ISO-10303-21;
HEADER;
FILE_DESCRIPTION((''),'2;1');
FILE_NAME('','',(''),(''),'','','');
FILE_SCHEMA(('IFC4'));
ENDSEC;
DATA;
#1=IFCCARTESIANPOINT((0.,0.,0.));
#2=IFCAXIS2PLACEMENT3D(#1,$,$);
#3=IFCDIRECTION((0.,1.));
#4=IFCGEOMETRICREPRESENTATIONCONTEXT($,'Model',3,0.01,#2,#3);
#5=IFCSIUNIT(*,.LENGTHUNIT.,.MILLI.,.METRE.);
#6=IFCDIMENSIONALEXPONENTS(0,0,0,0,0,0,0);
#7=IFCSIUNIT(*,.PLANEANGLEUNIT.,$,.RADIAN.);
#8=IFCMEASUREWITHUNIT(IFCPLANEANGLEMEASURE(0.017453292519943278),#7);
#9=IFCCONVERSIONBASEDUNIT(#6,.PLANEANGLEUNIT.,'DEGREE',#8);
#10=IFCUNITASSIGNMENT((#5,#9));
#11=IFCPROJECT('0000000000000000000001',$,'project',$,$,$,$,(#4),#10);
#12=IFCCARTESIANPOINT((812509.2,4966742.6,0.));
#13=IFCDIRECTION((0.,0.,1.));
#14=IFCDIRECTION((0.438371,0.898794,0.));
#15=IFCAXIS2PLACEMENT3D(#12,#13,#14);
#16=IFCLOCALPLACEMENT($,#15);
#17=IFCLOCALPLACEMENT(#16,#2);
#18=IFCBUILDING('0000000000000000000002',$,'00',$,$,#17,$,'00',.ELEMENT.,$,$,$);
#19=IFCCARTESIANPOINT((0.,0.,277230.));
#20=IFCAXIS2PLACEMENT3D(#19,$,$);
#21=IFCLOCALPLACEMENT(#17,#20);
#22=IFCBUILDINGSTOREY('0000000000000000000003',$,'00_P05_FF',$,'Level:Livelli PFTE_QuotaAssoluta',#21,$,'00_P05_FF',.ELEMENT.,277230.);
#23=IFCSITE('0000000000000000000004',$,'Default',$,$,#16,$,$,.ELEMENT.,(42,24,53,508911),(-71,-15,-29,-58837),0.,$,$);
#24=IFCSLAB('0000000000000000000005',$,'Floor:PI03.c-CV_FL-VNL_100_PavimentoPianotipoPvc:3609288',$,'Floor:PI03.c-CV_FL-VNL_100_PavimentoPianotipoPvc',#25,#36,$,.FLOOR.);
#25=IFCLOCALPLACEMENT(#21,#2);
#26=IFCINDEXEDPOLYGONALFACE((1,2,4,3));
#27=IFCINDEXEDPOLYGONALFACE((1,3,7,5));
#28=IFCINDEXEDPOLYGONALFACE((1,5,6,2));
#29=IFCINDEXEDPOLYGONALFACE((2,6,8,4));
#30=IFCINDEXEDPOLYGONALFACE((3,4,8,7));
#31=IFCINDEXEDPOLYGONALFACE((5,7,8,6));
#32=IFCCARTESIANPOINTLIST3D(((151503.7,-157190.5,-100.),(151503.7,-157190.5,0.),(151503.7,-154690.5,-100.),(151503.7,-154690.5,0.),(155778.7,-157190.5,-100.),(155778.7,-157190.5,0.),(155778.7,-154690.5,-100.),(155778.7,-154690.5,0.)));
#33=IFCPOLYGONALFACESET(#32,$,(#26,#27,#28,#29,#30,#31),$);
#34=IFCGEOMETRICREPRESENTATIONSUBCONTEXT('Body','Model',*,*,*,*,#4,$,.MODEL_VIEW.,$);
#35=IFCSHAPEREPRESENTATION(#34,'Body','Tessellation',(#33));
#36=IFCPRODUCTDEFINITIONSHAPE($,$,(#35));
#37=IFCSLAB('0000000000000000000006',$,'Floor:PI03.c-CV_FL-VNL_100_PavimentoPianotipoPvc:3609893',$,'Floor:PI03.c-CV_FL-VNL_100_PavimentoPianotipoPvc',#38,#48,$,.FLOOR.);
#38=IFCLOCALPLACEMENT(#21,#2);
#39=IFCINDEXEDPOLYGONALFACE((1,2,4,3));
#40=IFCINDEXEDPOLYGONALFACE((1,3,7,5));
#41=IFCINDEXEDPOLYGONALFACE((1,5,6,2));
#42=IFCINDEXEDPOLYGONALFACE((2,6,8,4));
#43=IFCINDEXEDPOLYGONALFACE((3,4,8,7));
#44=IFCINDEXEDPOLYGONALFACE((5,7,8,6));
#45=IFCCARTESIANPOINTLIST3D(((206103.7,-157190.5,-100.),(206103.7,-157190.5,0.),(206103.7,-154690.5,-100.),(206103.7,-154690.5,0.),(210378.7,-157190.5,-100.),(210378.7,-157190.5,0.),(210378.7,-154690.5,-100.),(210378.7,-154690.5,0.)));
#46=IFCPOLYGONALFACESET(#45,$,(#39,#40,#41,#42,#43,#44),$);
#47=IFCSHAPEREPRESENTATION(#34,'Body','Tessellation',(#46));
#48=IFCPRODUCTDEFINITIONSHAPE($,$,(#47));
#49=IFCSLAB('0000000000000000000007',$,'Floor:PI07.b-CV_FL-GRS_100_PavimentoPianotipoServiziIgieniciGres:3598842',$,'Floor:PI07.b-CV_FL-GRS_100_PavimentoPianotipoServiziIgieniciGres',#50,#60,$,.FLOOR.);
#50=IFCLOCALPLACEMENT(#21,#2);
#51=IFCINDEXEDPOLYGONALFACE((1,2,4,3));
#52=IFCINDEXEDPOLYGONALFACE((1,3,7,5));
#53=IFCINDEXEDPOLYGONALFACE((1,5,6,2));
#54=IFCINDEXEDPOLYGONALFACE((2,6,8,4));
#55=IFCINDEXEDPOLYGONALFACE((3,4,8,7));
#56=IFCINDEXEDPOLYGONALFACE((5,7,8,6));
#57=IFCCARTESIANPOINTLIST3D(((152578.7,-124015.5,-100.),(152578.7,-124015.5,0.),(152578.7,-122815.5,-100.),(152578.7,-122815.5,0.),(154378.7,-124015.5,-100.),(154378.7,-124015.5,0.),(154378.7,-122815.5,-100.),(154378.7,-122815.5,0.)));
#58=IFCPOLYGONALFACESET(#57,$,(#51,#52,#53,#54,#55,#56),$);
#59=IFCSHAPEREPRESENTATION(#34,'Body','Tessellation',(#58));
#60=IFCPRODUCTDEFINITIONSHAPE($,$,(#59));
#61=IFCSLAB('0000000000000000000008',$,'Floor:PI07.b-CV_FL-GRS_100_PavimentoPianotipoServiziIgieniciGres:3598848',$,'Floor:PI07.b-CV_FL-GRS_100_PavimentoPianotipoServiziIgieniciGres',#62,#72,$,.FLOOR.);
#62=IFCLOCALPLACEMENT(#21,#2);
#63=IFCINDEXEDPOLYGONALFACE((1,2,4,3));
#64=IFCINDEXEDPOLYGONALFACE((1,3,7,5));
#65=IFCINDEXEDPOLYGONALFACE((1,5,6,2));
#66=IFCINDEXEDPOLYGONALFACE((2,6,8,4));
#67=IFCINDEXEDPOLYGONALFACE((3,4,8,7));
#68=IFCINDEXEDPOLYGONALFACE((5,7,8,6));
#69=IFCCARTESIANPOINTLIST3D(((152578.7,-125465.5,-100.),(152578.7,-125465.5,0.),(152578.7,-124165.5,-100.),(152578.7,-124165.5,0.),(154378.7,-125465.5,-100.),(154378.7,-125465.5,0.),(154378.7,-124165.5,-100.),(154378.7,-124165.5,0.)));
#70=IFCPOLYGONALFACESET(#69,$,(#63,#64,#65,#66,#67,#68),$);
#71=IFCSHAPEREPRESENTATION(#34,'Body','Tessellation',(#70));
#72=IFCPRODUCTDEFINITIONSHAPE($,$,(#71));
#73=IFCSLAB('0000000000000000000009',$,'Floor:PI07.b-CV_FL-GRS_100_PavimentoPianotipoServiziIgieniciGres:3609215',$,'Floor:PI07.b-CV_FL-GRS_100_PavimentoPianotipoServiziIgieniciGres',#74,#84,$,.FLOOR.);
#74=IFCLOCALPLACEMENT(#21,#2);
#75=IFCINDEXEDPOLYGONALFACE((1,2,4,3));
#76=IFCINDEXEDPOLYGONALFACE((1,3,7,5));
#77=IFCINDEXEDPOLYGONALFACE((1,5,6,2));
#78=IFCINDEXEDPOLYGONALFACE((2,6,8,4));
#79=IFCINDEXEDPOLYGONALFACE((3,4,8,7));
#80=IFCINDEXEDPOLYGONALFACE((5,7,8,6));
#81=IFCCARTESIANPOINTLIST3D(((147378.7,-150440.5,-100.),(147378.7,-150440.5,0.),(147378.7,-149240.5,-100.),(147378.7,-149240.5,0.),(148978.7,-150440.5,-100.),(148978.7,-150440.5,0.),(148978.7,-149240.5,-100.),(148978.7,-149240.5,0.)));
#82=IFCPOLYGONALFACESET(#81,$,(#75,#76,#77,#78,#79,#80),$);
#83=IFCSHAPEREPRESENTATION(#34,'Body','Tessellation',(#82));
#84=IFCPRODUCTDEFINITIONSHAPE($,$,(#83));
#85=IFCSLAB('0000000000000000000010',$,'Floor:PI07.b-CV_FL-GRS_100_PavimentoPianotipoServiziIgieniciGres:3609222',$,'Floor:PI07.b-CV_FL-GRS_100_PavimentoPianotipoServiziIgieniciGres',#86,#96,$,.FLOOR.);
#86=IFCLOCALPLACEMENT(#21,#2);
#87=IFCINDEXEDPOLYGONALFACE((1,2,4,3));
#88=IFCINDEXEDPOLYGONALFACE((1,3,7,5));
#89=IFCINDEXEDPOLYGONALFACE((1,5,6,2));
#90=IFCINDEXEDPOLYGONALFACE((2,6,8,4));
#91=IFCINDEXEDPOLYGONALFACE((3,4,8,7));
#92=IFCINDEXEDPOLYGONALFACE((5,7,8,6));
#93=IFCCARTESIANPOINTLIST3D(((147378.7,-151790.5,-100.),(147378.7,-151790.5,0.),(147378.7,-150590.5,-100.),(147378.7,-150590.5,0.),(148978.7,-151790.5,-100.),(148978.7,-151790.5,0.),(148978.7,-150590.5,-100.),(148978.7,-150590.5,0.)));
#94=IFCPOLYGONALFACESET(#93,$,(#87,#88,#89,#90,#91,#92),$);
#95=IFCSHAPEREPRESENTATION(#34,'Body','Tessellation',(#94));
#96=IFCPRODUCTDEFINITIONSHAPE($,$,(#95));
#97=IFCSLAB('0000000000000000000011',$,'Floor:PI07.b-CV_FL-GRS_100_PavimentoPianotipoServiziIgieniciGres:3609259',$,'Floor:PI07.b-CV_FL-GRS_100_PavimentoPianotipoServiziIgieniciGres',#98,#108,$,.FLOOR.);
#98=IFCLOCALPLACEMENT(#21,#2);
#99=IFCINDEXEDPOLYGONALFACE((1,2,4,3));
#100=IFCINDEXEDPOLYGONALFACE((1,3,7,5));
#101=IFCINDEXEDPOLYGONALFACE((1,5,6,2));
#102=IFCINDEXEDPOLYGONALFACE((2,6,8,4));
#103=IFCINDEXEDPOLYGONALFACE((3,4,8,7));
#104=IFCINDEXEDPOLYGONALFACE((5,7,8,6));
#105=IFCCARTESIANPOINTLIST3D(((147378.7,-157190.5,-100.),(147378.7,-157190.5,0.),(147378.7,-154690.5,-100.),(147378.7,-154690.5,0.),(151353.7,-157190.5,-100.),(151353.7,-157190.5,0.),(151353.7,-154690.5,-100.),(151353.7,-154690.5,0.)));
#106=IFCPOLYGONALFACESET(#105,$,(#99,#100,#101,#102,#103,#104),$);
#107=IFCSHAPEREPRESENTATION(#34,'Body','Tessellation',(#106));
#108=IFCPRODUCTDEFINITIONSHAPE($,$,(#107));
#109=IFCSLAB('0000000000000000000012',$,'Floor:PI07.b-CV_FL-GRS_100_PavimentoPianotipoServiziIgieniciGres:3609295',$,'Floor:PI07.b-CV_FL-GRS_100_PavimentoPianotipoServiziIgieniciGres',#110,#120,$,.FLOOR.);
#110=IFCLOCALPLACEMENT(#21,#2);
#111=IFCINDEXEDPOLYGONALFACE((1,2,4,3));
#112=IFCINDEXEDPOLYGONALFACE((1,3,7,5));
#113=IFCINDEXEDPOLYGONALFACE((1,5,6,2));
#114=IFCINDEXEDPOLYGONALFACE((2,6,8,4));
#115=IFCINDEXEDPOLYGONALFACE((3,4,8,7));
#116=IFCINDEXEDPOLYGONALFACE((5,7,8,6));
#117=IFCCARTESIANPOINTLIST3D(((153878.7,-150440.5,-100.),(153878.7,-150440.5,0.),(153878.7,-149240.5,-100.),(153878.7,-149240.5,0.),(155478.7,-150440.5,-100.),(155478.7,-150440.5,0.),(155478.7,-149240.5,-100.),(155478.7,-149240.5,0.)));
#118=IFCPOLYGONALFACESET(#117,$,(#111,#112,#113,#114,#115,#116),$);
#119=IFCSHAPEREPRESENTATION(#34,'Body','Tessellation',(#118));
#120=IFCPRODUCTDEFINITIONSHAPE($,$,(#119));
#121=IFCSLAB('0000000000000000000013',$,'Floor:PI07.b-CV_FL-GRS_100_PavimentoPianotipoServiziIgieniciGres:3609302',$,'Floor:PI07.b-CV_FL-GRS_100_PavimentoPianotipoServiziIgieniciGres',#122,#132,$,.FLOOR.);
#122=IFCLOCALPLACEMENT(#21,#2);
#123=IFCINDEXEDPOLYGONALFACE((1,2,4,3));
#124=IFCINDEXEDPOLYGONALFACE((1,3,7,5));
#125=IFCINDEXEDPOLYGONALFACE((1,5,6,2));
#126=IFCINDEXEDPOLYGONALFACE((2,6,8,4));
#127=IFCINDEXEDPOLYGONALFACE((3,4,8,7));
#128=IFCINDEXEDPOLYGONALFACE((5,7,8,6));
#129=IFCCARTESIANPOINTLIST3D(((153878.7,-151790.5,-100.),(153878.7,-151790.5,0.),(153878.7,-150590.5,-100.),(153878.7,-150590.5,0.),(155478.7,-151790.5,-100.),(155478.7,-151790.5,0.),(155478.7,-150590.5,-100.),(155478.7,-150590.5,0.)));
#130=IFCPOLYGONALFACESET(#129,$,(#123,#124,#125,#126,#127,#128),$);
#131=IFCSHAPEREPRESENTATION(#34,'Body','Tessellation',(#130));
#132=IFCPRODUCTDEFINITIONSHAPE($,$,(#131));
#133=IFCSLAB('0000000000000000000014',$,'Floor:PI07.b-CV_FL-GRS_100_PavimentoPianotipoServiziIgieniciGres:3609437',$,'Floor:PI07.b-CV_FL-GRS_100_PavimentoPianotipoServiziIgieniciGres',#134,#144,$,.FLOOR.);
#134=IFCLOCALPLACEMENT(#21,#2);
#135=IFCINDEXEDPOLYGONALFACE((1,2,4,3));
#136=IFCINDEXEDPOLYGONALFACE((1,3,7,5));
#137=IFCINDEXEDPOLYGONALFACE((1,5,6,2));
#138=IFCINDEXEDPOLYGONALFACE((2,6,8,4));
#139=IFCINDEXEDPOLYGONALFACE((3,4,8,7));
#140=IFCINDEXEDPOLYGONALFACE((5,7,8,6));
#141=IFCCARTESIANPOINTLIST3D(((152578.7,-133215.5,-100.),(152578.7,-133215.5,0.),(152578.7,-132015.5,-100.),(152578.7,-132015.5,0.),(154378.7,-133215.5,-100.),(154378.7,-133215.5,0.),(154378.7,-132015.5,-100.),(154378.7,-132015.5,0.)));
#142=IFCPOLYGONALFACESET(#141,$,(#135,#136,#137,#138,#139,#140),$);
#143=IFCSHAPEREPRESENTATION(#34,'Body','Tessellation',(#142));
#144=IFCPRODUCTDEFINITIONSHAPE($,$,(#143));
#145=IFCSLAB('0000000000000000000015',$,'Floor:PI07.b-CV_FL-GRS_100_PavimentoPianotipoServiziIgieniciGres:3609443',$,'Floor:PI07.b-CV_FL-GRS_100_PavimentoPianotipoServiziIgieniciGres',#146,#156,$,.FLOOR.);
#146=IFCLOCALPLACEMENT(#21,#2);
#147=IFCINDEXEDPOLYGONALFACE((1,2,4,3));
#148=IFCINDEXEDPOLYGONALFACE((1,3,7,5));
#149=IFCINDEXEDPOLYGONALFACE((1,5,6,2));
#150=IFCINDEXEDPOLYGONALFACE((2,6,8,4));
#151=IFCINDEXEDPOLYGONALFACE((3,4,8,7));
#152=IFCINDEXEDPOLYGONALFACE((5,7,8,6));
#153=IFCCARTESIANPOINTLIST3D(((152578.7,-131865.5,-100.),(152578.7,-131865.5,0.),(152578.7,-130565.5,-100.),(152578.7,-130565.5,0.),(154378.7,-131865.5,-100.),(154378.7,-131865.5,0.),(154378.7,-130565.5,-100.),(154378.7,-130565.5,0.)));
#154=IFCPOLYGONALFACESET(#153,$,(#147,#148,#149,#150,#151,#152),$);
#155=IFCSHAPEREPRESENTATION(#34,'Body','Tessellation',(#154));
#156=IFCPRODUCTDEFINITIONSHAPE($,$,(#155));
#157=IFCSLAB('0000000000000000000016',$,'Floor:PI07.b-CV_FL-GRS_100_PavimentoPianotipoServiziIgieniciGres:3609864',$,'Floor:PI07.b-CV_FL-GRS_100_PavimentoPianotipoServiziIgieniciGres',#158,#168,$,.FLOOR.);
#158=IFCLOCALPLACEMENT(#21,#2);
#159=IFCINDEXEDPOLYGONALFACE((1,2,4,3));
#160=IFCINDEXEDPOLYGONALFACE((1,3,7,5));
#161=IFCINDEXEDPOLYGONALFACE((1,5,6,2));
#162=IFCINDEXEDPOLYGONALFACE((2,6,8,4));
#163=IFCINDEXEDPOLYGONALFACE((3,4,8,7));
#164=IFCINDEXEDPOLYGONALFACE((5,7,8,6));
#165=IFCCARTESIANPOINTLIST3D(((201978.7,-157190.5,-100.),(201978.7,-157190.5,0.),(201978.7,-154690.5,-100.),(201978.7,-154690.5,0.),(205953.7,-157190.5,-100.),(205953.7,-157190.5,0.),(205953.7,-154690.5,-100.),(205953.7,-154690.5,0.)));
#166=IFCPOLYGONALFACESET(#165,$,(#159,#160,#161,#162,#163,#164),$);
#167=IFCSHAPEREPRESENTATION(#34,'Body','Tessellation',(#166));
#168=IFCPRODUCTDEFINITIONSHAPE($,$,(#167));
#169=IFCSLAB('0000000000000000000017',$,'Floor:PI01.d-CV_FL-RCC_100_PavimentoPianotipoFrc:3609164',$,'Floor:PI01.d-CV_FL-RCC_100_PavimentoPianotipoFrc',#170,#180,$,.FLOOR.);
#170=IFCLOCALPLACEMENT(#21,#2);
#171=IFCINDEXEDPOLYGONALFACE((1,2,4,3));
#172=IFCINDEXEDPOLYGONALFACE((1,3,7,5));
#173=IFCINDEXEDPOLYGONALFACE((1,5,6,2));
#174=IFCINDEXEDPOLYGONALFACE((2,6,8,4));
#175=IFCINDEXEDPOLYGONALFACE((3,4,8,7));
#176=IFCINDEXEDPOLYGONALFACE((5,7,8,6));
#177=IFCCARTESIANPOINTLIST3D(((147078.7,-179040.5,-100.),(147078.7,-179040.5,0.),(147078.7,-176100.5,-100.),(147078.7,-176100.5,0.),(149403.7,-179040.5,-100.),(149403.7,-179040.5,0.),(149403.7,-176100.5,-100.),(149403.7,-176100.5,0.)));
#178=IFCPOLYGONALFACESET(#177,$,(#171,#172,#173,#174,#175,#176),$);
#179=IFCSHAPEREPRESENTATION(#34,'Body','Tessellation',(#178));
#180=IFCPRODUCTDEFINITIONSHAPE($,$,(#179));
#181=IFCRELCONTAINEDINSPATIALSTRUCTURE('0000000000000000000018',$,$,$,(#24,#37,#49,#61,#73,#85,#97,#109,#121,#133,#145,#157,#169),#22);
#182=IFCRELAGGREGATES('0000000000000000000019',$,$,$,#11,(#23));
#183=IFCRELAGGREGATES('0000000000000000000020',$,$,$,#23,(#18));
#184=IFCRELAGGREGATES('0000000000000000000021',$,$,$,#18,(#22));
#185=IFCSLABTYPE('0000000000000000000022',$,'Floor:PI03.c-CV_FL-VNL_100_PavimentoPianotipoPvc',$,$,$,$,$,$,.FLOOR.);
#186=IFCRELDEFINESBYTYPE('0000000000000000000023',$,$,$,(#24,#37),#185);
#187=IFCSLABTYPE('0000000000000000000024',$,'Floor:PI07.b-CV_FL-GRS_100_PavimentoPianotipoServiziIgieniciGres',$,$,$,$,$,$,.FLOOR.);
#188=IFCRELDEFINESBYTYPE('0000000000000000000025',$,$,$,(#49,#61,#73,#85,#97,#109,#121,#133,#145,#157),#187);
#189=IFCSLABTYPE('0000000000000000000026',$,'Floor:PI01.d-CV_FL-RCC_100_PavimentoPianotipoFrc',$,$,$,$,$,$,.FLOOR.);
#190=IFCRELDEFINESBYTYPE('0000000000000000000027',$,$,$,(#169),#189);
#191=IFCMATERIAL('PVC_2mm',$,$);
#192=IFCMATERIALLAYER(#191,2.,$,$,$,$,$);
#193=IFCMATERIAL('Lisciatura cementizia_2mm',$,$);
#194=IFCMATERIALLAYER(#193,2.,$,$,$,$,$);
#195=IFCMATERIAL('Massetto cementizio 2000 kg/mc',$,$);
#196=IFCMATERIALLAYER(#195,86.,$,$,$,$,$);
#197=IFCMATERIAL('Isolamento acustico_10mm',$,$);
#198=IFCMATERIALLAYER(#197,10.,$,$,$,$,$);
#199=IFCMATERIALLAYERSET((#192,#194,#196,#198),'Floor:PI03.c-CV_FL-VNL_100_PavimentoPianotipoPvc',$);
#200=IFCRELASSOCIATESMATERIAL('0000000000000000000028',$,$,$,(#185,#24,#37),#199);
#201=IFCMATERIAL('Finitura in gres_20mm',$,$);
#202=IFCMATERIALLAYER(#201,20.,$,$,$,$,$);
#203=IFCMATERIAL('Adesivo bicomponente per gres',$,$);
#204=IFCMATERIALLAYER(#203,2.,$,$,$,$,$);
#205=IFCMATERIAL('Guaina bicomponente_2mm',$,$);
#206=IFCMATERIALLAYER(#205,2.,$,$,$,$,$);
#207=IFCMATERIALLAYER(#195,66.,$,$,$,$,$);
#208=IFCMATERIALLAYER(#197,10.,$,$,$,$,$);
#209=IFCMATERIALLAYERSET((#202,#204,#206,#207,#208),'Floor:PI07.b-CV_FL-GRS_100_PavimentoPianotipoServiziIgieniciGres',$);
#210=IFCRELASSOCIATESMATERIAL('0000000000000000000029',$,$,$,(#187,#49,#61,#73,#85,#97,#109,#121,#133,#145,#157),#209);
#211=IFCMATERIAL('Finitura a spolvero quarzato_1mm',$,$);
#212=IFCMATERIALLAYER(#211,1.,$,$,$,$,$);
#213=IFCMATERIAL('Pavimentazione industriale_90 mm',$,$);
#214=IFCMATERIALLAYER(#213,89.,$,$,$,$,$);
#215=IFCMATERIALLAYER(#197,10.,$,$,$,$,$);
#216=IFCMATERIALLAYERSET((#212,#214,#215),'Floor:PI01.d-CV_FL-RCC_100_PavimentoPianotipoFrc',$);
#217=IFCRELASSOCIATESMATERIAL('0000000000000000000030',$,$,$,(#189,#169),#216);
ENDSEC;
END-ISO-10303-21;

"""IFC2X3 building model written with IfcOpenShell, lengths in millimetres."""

from ifc_helpers import new_model, entity, si_unit, converted_unit, direction, frame, frame_2d, origin, origin_2d_with_axis, place, context, subcontext, project, spatial, rectangle, extrude, material, layer, layer_set, layer_usage, type_object, element, save


model = new_model("IFC2X3")

# Units and contexts
model_context = context("Model", 3, precision=0.01, world=origin(), true_north=direction((0.0, 1.0)))
body_context = subcontext(model_context, "Body", "Model", "MODEL_VIEW")
ifc_project = project(units=[si_unit("LENGTHUNIT", "METRE", prefix="MILLI"), converted_unit("PLANEANGLEUNIT", "DEGREE", entity("IfcPlaneAngleMeasure", 0.017453292519943278), si_unit("PLANEANGLEUNIT", "RADIAN"), dimensions=[0, 0, 0, 0, 0, 0, 0])], contexts=[model_context])

# Site, building, storey
site_placement = place(None, frame((812509.2, 4966742.6, 0.0), z_axis=(0.0, 0.0, 1.0), x_axis=(0.438371, 0.898794, 0.0)))
site = spatial("IfcSite", under=ifc_project, at=site_placement, Name="Default", CompositionType="ELEMENT", RefLatitude=(42, 24, 53, 508911), RefLongitude=(-71, -15, -29, -58837), RefElevation=0.0)
building_placement = place(site_placement, origin())
building = spatial("IfcBuilding", under=site, at=building_placement, Name="00", LongName="00", CompositionType="ELEMENT")
storey_placement = place(building_placement, frame((0.0, 0.0, 277230.0)))
storey = spatial("IfcBuildingStorey", under=building, at=storey_placement, Name="00_P05_FF", ObjectType="Level:Livelli PFTE_QuotaAssoluta", LongName="00_P05_FF", CompositionType="ELEMENT", Elevation=277230.0)

# Slabs
ifc_material_1 = material(Name="PVC_2mm")
ifc_layer_1 = layer(ifc_material_1, 2.0)
ifc_material_2 = material(Name="Lisciatura cementizia_2mm")
ifc_layer_2 = layer(ifc_material_2, 2.0)
ifc_material_3 = material(Name="Massetto cementizio 2000 kg/mc")
ifc_layer_3 = layer(ifc_material_3, 86.0)
ifc_material_4 = material(Name="Isolamento acustico_10mm")
ifc_layer_4 = layer(ifc_material_4, 10.0)
ifc_layer_set_1 = layer_set([ifc_layer_1, ifc_layer_2, ifc_layer_3, ifc_layer_4], Name="Floor:PI03.c-CV_FL-VNL_100_PavimentoPianotipoPvc")
slab_type_1 = type_object("IfcSlabType", Name="Floor:PI03.c-CV_FL-VNL_100_PavimentoPianotipoPvc", PredefinedType="FLOOR", material=ifc_layer_set_1)
ifc_layer_usage_1 = layer_usage(ifc_layer_set_1, "AXIS3", "POSITIVE", 0.0)
slab_1_placement = place(storey_placement, origin())
element("IfcSlab", 1, at=slab_1_placement, inside=storey, type_object=slab_type_1, material=ifc_layer_usage_1, Name="Floor:PI03.c-CV_FL-VNL_100_PavimentoPianotipoPvc:3609288", ObjectType="Floor:PI03.c-CV_FL-VNL_100_PavimentoPianotipoPvc", PredefinedType="FLOOR", context=body_context, shape_type="SweptSolid", body=[
    extrude(rectangle(XDim=2500.0, YDim=4275.0, at=frame_2d((0.0, 0.0), x_axis=(1.0, 0.0))), frame((153641.2, -155940.5, 0.0), z_axis=(0.0, 0.0, -1.0), x_axis=(0.0, 1.0, 0.0)), (0.0, 0.0, 1.0), 100.0),
])
ifc_layer_usage_2 = layer_usage(ifc_layer_set_1, "AXIS3", "POSITIVE", 0.0)
slab_2_placement = place(storey_placement, origin())
element("IfcSlab", 2, at=slab_2_placement, inside=storey, type_object=slab_type_1, material=ifc_layer_usage_2, Name="Floor:PI03.c-CV_FL-VNL_100_PavimentoPianotipoPvc:3609893", ObjectType="Floor:PI03.c-CV_FL-VNL_100_PavimentoPianotipoPvc", PredefinedType="FLOOR", context=body_context, shape_type="SweptSolid", body=[
    extrude(rectangle(XDim=2500.0, YDim=4275.0, at=frame_2d((0.0, 0.0), x_axis=(1.0, 0.0))), frame((208241.2, -155940.5, 0.0), z_axis=(0.0, 0.0, -1.0), x_axis=(0.0, 1.0, 0.0)), (0.0, 0.0, 1.0), 100.0),
])
ifc_material_5 = material(Name="Finitura in gres_20mm")
ifc_layer_5 = layer(ifc_material_5, 20.0)
ifc_material_6 = material(Name="Adesivo bicomponente per gres")
ifc_layer_6 = layer(ifc_material_6, 2.0)
ifc_material_7 = material(Name="Guaina bicomponente_2mm")
ifc_layer_7 = layer(ifc_material_7, 2.0)
ifc_layer_8 = layer(ifc_material_3, 66.0)
ifc_layer_9 = layer(ifc_material_4, 10.0)
ifc_layer_set_2 = layer_set([ifc_layer_5, ifc_layer_6, ifc_layer_7, ifc_layer_8, ifc_layer_9], Name="Floor:PI07.b-CV_FL-GRS_100_PavimentoPianotipoServiziIgieniciGres")
slab_type_2 = type_object("IfcSlabType", Name="Floor:PI07.b-CV_FL-GRS_100_PavimentoPianotipoServiziIgieniciGres", PredefinedType="FLOOR", material=ifc_layer_set_2)
ifc_layer_usage_3 = layer_usage(ifc_layer_set_2, "AXIS3", "POSITIVE", 0.0)
slab_3_placement = place(storey_placement, origin())
element("IfcSlab", 3, at=slab_3_placement, inside=storey, type_object=slab_type_2, material=ifc_layer_usage_3, Name="Floor:PI07.b-CV_FL-GRS_100_PavimentoPianotipoServiziIgieniciGres:3598842", ObjectType="Floor:PI07.b-CV_FL-GRS_100_PavimentoPianotipoServiziIgieniciGres", PredefinedType="FLOOR", context=body_context, shape_type="SweptSolid", body=[
    extrude(rectangle(XDim=1200.0, YDim=1800.0, at=frame_2d((0.0, 0.0), x_axis=(1.0, 0.0))), frame((153478.7, -123415.5, 0.0), z_axis=(0.0, 0.0, -1.0), x_axis=(0.0, 1.0, 0.0)), (0.0, 0.0, 1.0), 100.0),
])
ifc_layer_usage_4 = layer_usage(ifc_layer_set_2, "AXIS3", "POSITIVE", 0.0)
slab_4_placement = place(storey_placement, origin())
element("IfcSlab", 4, at=slab_4_placement, inside=storey, type_object=slab_type_2, material=ifc_layer_usage_4, Name="Floor:PI07.b-CV_FL-GRS_100_PavimentoPianotipoServiziIgieniciGres:3598848", ObjectType="Floor:PI07.b-CV_FL-GRS_100_PavimentoPianotipoServiziIgieniciGres", PredefinedType="FLOOR", context=body_context, shape_type="SweptSolid", body=[
    extrude(rectangle(XDim=1300.0, YDim=1800.0, at=frame_2d((0.0, 0.0), x_axis=(1.0, 0.0))), frame((153478.7, -124815.5, 0.0), z_axis=(0.0, 0.0, -1.0), x_axis=(0.0, 1.0, 0.0)), (0.0, 0.0, 1.0), 100.0),
])
ifc_layer_usage_5 = layer_usage(ifc_layer_set_2, "AXIS3", "POSITIVE", 0.0)
slab_5_placement = place(storey_placement, origin())
element("IfcSlab", 5, at=slab_5_placement, inside=storey, type_object=slab_type_2, material=ifc_layer_usage_5, Name="Floor:PI07.b-CV_FL-GRS_100_PavimentoPianotipoServiziIgieniciGres:3609215", ObjectType="Floor:PI07.b-CV_FL-GRS_100_PavimentoPianotipoServiziIgieniciGres", PredefinedType="FLOOR", context=body_context, shape_type="SweptSolid", body=[
    extrude(rectangle(XDim=1200.0, YDim=1600.0, at=origin_2d_with_axis()), frame((148178.7, -149840.5, 0.0), z_axis=(0.0, 0.0, -1.0), x_axis=(0.0, 1.0, 0.0)), (0.0, 0.0, 1.0), 100.0),
])
ifc_layer_usage_6 = layer_usage(ifc_layer_set_2, "AXIS3", "POSITIVE", 0.0)
slab_6_placement = place(storey_placement, origin())
element("IfcSlab", 6, at=slab_6_placement, inside=storey, type_object=slab_type_2, material=ifc_layer_usage_6, Name="Floor:PI07.b-CV_FL-GRS_100_PavimentoPianotipoServiziIgieniciGres:3609222", ObjectType="Floor:PI07.b-CV_FL-GRS_100_PavimentoPianotipoServiziIgieniciGres", PredefinedType="FLOOR", context=body_context, shape_type="SweptSolid", body=[
    extrude(rectangle(XDim=1200.0, YDim=1600.0, at=frame_2d((0.0, 0.0), x_axis=(1.0, 0.0))), frame((148178.7, -151190.5, 0.0), z_axis=(0.0, 0.0, -1.0), x_axis=(0.0, 1.0, 0.0)), (0.0, 0.0, 1.0), 100.0),
])
ifc_layer_usage_7 = layer_usage(ifc_layer_set_2, "AXIS3", "POSITIVE", 0.0)
slab_7_placement = place(storey_placement, origin())
element("IfcSlab", 7, at=slab_7_placement, inside=storey, type_object=slab_type_2, material=ifc_layer_usage_7, Name="Floor:PI07.b-CV_FL-GRS_100_PavimentoPianotipoServiziIgieniciGres:3609259", ObjectType="Floor:PI07.b-CV_FL-GRS_100_PavimentoPianotipoServiziIgieniciGres", PredefinedType="FLOOR", context=body_context, shape_type="SweptSolid", body=[
    extrude(rectangle(XDim=2500.0, YDim=3975.0, at=frame_2d((0.0, 0.0), x_axis=(1.0, 0.0))), frame((149366.2, -155940.5, 0.0), z_axis=(0.0, 0.0, -1.0), x_axis=(0.0, 1.0, 0.0)), (0.0, 0.0, 1.0), 100.0),
])
ifc_layer_usage_8 = layer_usage(ifc_layer_set_2, "AXIS3", "POSITIVE", 0.0)
slab_8_placement = place(storey_placement, origin())
element("IfcSlab", 8, at=slab_8_placement, inside=storey, type_object=slab_type_2, material=ifc_layer_usage_8, Name="Floor:PI07.b-CV_FL-GRS_100_PavimentoPianotipoServiziIgieniciGres:3609295", ObjectType="Floor:PI07.b-CV_FL-GRS_100_PavimentoPianotipoServiziIgieniciGres", PredefinedType="FLOOR", context=body_context, shape_type="SweptSolid", body=[
    extrude(rectangle(XDim=1200.0, YDim=1600.0, at=frame_2d((0.0, 0.0), x_axis=(1.0, 0.0))), frame((154678.7, -149840.5, 0.0), z_axis=(0.0, 0.0, -1.0), x_axis=(0.0, 1.0, 0.0)), (0.0, 0.0, 1.0), 100.0),
])
ifc_layer_usage_9 = layer_usage(ifc_layer_set_2, "AXIS3", "POSITIVE", 0.0)
slab_9_placement = place(storey_placement, origin())
element("IfcSlab", 9, at=slab_9_placement, inside=storey, type_object=slab_type_2, material=ifc_layer_usage_9, Name="Floor:PI07.b-CV_FL-GRS_100_PavimentoPianotipoServiziIgieniciGres:3609302", ObjectType="Floor:PI07.b-CV_FL-GRS_100_PavimentoPianotipoServiziIgieniciGres", PredefinedType="FLOOR", context=body_context, shape_type="SweptSolid", body=[
    extrude(rectangle(XDim=1200.0, YDim=1600.0, at=frame_2d((0.0, 0.0), x_axis=(1.0, 0.0))), frame((154678.7, -151190.5, 0.0), z_axis=(0.0, 0.0, -1.0), x_axis=(0.0, 1.0, 0.0)), (0.0, 0.0, 1.0), 100.0),
])
ifc_layer_usage_10 = layer_usage(ifc_layer_set_2, "AXIS3", "POSITIVE", 0.0)
slab_10_placement = place(storey_placement, origin())
element("IfcSlab", 10, at=slab_10_placement, inside=storey, type_object=slab_type_2, material=ifc_layer_usage_10, Name="Floor:PI07.b-CV_FL-GRS_100_PavimentoPianotipoServiziIgieniciGres:3609437", ObjectType="Floor:PI07.b-CV_FL-GRS_100_PavimentoPianotipoServiziIgieniciGres", PredefinedType="FLOOR", context=body_context, shape_type="SweptSolid", body=[
    extrude(rectangle(XDim=1200.0, YDim=1800.0, at=frame_2d((0.0, 0.0), x_axis=(1.0, 0.0))), frame((153478.7, -132615.5, 0.0), z_axis=(0.0, 0.0, -1.0), x_axis=(0.0, 1.0, 0.0)), (0.0, 0.0, 1.0), 100.0),
])
ifc_layer_usage_11 = layer_usage(ifc_layer_set_2, "AXIS3", "POSITIVE", 0.0)
slab_11_placement = place(storey_placement, origin())
element("IfcSlab", 11, at=slab_11_placement, inside=storey, type_object=slab_type_2, material=ifc_layer_usage_11, Name="Floor:PI07.b-CV_FL-GRS_100_PavimentoPianotipoServiziIgieniciGres:3609443", ObjectType="Floor:PI07.b-CV_FL-GRS_100_PavimentoPianotipoServiziIgieniciGres", PredefinedType="FLOOR", context=body_context, shape_type="SweptSolid", body=[
    extrude(rectangle(XDim=1300.0, YDim=1800.0, at=frame_2d((0.0, 0.0), x_axis=(1.0, 0.0))), frame((153478.7, -131215.5, 0.0), z_axis=(0.0, 0.0, -1.0), x_axis=(0.0, 1.0, 0.0)), (0.0, 0.0, 1.0), 100.0),
])
ifc_layer_usage_12 = layer_usage(ifc_layer_set_2, "AXIS3", "POSITIVE", 0.0)
slab_12_placement = place(storey_placement, origin())
element("IfcSlab", 12, at=slab_12_placement, inside=storey, type_object=slab_type_2, material=ifc_layer_usage_12, Name="Floor:PI07.b-CV_FL-GRS_100_PavimentoPianotipoServiziIgieniciGres:3609864", ObjectType="Floor:PI07.b-CV_FL-GRS_100_PavimentoPianotipoServiziIgieniciGres", PredefinedType="FLOOR", context=body_context, shape_type="SweptSolid", body=[
    extrude(rectangle(XDim=2500.0, YDim=3975.0, at=frame_2d((0.0, 0.0), x_axis=(1.0, 0.0))), frame((203966.2, -155940.5, 0.0), z_axis=(0.0, 0.0, -1.0), x_axis=(0.0, 1.0, 0.0)), (0.0, 0.0, 1.0), 100.0),
])
ifc_material_8 = material(Name="Finitura a spolvero quarzato_1mm")
ifc_layer_10 = layer(ifc_material_8, 1.0)
ifc_material_9 = material(Name="Pavimentazione industriale_90 mm")
ifc_layer_11 = layer(ifc_material_9, 89.0)
ifc_layer_12 = layer(ifc_material_4, 10.0)
ifc_layer_set_3 = layer_set([ifc_layer_10, ifc_layer_11, ifc_layer_12], Name="Floor:PI01.d-CV_FL-RCC_100_PavimentoPianotipoFrc")
ifc_layer_usage_13 = layer_usage(ifc_layer_set_3, "AXIS3", "POSITIVE", 0.0)
slab_type_3 = type_object("IfcSlabType", Name="Floor:PI01.d-CV_FL-RCC_100_PavimentoPianotipoFrc", PredefinedType="FLOOR", material=ifc_layer_set_3)
slab_13_placement = place(storey_placement, origin())
element("IfcSlab", 13, at=slab_13_placement, inside=storey, type_object=slab_type_3, material=ifc_layer_usage_13, Name="Floor:PI01.d-CV_FL-RCC_100_PavimentoPianotipoFrc:3609164", ObjectType="Floor:PI01.d-CV_FL-RCC_100_PavimentoPianotipoFrc", PredefinedType="FLOOR", context=body_context, shape_type="SweptSolid", body=[
    extrude(rectangle(XDim=2940.0, YDim=2325.0, at=origin_2d_with_axis()), frame((148241.2, -177570.5, 0.0), z_axis=(0.0, 0.0, -1.0), x_axis=(0.0, 1.0, 0.0)), (0.0, 0.0, 1.0), 100.0),
])

save(model, "model.ifc")
